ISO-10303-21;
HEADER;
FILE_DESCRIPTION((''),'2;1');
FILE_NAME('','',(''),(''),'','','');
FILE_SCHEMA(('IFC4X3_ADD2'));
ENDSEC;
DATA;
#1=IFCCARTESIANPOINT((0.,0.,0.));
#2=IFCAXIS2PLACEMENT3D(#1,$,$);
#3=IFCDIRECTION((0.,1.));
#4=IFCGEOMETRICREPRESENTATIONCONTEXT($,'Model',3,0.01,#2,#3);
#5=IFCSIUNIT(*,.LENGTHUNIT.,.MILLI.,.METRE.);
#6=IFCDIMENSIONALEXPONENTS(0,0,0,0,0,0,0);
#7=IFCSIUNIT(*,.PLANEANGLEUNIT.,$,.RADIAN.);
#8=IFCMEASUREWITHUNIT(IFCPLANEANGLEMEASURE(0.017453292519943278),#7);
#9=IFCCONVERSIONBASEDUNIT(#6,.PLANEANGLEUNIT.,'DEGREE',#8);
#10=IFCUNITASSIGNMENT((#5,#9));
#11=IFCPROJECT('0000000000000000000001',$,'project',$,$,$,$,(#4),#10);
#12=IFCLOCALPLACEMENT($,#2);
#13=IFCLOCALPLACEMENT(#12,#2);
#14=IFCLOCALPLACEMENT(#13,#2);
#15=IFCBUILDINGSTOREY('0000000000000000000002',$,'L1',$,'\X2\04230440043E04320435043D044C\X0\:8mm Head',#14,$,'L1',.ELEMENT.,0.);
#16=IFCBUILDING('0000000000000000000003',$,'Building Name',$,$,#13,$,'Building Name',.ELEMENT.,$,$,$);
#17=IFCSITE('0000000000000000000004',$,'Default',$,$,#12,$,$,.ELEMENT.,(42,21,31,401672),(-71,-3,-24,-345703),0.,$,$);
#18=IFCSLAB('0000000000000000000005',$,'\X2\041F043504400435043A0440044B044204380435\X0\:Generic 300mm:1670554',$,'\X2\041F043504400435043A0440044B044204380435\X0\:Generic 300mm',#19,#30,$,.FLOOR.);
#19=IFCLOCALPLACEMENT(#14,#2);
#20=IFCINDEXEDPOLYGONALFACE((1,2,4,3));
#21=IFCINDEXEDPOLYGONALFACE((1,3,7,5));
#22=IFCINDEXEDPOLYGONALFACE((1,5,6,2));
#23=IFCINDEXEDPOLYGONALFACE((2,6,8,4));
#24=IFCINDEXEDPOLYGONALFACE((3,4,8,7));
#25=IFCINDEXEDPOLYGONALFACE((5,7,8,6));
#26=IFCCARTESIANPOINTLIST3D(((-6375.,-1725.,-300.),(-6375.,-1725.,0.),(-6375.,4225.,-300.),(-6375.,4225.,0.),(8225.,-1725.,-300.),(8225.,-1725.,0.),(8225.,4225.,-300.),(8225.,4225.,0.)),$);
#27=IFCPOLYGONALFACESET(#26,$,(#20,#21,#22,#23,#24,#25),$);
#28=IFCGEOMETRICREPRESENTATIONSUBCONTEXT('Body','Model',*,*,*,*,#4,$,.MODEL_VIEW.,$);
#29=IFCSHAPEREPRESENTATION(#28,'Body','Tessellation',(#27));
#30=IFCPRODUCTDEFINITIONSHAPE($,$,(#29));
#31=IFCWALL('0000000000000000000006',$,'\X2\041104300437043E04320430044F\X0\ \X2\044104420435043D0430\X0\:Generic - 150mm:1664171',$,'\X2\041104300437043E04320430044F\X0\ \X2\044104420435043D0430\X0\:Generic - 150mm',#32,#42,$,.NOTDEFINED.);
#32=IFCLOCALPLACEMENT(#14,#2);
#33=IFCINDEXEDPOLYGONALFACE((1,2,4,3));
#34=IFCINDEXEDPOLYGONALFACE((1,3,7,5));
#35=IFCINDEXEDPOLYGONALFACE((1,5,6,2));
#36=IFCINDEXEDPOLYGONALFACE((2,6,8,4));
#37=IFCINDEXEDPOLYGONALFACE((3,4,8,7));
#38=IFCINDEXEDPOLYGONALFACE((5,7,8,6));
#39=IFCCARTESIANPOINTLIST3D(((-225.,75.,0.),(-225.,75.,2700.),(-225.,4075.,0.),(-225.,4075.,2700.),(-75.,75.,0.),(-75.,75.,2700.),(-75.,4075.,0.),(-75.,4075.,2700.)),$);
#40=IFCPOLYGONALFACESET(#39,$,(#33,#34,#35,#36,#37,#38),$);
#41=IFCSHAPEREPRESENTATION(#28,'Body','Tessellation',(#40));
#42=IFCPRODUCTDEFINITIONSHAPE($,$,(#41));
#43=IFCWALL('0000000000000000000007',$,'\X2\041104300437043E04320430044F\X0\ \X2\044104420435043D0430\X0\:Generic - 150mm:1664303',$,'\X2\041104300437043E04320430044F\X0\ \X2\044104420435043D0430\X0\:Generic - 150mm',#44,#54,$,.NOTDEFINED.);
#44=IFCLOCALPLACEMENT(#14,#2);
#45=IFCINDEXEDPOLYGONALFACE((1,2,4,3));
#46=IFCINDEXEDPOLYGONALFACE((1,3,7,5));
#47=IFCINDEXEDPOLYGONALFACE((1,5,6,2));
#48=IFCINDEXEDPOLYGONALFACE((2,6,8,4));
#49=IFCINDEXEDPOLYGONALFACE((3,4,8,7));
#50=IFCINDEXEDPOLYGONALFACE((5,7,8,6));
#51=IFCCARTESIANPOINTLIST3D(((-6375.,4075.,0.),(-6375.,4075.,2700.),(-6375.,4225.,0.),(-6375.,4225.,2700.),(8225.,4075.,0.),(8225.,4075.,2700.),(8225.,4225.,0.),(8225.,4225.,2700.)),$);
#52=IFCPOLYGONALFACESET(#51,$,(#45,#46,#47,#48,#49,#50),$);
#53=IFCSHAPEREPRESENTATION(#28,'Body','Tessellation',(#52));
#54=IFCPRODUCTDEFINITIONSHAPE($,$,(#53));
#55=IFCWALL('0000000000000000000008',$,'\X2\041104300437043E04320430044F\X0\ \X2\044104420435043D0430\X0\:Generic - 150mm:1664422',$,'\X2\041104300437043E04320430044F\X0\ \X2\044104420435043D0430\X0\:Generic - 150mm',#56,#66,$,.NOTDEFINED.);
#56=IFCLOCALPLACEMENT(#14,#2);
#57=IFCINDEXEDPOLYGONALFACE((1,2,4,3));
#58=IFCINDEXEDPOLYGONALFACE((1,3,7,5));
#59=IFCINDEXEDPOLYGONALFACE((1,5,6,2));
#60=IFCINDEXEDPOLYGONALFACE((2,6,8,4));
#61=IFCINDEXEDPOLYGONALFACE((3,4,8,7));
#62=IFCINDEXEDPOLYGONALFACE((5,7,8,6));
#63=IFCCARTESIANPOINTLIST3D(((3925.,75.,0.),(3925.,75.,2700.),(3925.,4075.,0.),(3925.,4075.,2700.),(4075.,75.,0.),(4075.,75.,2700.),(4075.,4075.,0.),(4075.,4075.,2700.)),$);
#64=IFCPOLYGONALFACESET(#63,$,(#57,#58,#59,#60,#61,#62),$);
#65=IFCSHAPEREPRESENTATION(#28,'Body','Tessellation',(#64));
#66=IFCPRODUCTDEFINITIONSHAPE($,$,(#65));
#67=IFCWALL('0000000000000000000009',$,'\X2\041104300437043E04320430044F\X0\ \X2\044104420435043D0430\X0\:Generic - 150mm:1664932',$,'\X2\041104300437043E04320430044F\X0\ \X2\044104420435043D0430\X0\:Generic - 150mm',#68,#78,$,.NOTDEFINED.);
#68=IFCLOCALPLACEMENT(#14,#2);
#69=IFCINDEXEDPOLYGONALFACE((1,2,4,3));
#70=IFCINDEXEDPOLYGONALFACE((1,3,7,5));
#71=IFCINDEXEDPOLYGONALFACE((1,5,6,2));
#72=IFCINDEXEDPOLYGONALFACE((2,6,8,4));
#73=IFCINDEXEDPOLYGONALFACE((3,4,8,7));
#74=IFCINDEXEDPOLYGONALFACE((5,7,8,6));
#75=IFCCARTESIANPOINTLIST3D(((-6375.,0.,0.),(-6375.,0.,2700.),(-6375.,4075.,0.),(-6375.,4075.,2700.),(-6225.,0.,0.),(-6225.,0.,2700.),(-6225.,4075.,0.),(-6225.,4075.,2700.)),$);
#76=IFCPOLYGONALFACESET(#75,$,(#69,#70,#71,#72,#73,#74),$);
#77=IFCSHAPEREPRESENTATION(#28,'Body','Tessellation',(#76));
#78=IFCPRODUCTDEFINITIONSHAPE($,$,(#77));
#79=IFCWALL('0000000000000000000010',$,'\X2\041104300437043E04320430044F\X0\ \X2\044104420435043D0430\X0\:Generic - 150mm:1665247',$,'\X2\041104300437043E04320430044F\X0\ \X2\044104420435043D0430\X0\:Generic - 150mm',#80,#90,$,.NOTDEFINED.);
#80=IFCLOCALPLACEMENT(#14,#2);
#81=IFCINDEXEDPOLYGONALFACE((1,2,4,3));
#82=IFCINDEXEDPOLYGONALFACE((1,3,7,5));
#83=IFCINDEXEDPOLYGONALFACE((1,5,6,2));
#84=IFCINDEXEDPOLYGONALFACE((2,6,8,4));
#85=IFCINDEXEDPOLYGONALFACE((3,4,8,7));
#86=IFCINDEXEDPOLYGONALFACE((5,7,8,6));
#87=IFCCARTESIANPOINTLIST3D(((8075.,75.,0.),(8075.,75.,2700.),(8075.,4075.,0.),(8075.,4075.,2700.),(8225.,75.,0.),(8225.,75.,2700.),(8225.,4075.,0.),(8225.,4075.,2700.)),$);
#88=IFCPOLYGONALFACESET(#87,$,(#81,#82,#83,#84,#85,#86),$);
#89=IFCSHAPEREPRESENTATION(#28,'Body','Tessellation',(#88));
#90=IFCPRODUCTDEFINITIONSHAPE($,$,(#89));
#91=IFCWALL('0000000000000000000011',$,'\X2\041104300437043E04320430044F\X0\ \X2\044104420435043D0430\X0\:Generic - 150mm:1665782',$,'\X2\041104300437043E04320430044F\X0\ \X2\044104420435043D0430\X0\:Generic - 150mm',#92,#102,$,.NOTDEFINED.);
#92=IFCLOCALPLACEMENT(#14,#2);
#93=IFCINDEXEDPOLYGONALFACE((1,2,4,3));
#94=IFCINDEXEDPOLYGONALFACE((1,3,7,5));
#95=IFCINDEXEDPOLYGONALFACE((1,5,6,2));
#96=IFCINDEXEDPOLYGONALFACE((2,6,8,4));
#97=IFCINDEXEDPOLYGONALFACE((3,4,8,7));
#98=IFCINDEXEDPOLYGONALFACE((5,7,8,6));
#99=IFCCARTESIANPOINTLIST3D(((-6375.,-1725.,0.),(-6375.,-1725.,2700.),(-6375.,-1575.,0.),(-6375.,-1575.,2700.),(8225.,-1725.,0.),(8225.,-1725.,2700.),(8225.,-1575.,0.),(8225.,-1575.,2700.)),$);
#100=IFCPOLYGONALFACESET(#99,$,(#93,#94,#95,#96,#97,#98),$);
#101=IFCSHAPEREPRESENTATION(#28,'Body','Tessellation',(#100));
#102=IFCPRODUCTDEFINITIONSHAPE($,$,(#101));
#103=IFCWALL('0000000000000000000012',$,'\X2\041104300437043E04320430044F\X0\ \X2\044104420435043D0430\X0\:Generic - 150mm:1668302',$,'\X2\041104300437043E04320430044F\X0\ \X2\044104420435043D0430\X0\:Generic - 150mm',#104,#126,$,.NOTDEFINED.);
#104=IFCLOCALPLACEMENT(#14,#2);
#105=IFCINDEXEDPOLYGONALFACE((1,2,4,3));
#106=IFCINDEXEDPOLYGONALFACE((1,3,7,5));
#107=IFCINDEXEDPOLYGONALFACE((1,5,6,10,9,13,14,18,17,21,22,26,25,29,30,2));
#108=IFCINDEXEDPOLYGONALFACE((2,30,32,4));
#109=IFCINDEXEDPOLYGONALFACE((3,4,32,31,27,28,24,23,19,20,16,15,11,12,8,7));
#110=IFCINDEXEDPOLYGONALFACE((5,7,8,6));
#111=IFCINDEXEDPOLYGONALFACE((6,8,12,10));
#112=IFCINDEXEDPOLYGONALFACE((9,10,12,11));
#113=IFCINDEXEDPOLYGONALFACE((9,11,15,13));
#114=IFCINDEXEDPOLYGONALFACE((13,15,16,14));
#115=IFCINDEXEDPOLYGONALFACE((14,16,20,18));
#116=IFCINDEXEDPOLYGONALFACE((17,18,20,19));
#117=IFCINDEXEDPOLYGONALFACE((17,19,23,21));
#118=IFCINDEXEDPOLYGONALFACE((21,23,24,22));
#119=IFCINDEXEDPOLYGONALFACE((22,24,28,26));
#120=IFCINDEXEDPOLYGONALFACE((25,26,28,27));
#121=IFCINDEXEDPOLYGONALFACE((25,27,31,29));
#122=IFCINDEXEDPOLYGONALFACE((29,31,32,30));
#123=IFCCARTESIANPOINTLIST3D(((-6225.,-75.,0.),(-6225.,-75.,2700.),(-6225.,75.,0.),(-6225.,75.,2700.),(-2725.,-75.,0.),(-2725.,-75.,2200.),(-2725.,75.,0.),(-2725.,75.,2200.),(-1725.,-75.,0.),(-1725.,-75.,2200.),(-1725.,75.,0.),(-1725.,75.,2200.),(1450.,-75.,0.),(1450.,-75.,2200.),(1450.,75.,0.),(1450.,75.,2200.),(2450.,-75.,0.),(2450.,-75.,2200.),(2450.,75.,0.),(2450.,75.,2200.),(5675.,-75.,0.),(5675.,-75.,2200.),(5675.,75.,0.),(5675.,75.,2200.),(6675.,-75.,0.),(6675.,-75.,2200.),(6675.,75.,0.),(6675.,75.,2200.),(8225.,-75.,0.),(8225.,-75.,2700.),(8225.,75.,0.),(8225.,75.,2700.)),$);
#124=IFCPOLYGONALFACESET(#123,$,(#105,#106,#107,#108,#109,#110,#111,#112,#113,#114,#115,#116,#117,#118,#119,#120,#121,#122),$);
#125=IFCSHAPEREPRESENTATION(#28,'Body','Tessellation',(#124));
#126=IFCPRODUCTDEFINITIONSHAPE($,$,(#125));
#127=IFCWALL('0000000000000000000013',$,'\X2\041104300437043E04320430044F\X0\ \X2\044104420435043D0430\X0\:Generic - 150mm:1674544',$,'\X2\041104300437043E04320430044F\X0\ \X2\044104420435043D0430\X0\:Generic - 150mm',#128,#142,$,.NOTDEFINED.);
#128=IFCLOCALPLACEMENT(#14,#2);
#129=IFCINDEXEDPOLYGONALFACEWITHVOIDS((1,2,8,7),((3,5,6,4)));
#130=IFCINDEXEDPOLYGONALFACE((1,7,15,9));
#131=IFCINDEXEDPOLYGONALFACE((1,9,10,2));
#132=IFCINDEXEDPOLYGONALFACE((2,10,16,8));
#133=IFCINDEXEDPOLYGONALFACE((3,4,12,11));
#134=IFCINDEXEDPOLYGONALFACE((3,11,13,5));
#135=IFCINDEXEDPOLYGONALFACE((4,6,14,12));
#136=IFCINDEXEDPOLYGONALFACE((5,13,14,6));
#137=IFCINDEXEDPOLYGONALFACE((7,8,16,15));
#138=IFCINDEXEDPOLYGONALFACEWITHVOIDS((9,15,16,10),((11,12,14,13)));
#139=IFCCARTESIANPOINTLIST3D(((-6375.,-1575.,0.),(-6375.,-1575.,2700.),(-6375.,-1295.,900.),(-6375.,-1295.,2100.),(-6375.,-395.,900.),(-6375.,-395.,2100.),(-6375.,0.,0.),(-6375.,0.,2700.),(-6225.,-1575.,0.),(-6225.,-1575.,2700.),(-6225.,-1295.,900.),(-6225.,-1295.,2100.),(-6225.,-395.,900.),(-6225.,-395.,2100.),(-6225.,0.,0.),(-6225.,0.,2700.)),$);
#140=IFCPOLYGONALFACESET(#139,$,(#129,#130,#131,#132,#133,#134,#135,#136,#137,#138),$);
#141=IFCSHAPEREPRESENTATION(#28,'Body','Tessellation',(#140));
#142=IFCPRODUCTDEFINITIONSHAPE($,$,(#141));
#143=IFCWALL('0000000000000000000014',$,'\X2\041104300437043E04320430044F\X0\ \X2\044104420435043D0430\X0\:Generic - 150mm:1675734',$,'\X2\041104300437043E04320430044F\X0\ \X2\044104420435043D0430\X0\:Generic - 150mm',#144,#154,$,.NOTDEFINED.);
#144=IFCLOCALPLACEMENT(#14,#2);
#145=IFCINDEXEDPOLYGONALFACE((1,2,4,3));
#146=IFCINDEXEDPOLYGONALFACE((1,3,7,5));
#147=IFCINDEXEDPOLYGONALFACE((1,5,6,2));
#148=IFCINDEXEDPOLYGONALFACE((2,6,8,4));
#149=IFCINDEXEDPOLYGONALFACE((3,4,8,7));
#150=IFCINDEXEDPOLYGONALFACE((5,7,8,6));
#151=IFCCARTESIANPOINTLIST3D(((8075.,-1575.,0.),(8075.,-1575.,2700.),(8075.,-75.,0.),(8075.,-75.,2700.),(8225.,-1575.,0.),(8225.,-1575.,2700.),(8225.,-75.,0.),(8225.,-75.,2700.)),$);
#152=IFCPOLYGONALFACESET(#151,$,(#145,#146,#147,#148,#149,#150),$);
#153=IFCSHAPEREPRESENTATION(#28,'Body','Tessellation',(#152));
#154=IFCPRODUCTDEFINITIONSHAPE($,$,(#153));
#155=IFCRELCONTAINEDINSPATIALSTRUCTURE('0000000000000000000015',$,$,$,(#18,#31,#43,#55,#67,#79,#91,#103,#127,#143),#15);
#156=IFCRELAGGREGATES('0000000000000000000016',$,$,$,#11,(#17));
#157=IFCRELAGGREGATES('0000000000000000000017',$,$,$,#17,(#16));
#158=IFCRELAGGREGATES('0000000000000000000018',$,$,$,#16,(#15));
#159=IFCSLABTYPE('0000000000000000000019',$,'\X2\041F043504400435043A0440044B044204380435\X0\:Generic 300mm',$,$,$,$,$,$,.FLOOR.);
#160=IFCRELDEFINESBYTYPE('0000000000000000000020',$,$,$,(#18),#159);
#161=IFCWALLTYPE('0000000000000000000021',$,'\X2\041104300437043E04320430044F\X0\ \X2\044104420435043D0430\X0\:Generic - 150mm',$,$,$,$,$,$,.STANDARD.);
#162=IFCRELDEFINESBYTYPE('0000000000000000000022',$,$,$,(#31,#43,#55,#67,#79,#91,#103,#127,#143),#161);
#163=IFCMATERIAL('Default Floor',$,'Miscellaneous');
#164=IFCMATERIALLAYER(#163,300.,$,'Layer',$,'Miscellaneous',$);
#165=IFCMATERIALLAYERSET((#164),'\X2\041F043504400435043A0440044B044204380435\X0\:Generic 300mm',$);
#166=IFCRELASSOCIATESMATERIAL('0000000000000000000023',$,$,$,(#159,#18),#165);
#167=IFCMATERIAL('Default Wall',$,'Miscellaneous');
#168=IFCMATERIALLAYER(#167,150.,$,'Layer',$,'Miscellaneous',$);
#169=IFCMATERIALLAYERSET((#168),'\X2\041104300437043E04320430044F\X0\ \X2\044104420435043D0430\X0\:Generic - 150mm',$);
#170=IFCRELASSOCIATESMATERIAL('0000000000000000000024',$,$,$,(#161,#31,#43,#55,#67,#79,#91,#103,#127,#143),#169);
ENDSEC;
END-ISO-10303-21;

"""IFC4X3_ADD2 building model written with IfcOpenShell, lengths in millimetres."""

from ifc_helpers import new_model, entity, si_unit, converted_unit, direction, frame, frame_2d, origin, origin_2d_with_axis, place, context, subcontext, project, spatial, rectangle, extrude, material, layer, layer_set, layer_usage, type_object, element, save


model = new_model("IFC4X3_ADD2")

# Units and contexts
model_context = context("Model", 3, precision=0.01, world=origin(), true_north=direction((0.0, 1.0)))
body_context = subcontext(model_context, "Body", "Model", "MODEL_VIEW")
ifc_project = project(units=[si_unit("LENGTHUNIT", "METRE", prefix="MILLI"), converted_unit("PLANEANGLEUNIT", "DEGREE", entity("IfcPlaneAngleMeasure", 0.017453292519943278), si_unit("PLANEANGLEUNIT", "RADIAN"), dimensions=[0, 0, 0, 0, 0, 0, 0])], contexts=[model_context])

# Site, building, storey
site_placement = place(None, origin())
site = spatial("IfcSite", under=ifc_project, at=site_placement, Name="Default", CompositionType="ELEMENT", RefLatitude=(42, 21, 31, 401672), RefLongitude=(-71, -3, -24, -345703), RefElevation=0.0)
building_placement = place(site_placement, origin())
building = spatial("IfcBuilding", under=site, at=building_placement, Name="Building Name", LongName="Building Name", CompositionType="ELEMENT")
storey_placement = place(building_placement, origin())
storey = spatial("IfcBuildingStorey", under=building, at=storey_placement, Name="L1", ObjectType="Уровень:8mm Head", LongName="L1", CompositionType="ELEMENT", Elevation=0.0)

# Slab
ifc_material_1 = material(Name="Default Floor", Category="Miscellaneous")
ifc_layer_1 = layer(ifc_material_1, 300.0, Name="Layer", Category="Miscellaneous")
ifc_layer_set_1 = layer_set([ifc_layer_1], Name="Перекрытие:Generic 300mm")
ifc_layer_usage = layer_usage(ifc_layer_set_1, "AXIS3", "POSITIVE", 0.0)
slab_type = type_object("IfcSlabType", Name="Перекрытие:Generic 300mm", PredefinedType="FLOOR", material=ifc_layer_set_1)
slab_placement = place(storey_placement, origin())
element("IfcSlab", 1, at=slab_placement, inside=storey, type_object=slab_type, material=ifc_layer_usage, Name="Перекрытие:Generic 300mm:1670554", ObjectType="Перекрытие:Generic 300mm", PredefinedType="FLOOR", context=body_context, shape_type="SweptSolid", body=[
    extrude(rectangle(XDim=5950.0, YDim=14600.0, at=origin_2d_with_axis()), frame((925.0, 1250.0, 0.0), z_axis=(0.0, 0.0, -1.0), x_axis=(0.0, 1.0, 0.0)), (0.0, 0.0, 1.0), 300.0),
])

# Walls
ifc_material_2 = material(Name="Default Wall", Category="Miscellaneous")
ifc_layer_2 = layer(ifc_material_2, 150.0, Name="Layer", Category="Miscellaneous")
ifc_layer_set_2 = layer_set([ifc_layer_2], Name="Базовая стена:Generic - 150mm")
wall_type = type_object("IfcWallType", Name="Базовая стена:Generic - 150mm", PredefinedType="STANDARD", material=ifc_layer_set_2)
wall_1_placement = place(storey_placement, frame((-150.0, 75.0, 0.0), z_axis=(0.0, 0.0, 1.0), x_axis=(0.0, 1.0, 0.0)))
element("IfcWall", 2, at=wall_1_placement, inside=storey, type_object=wall_type, material=ifc_layer_set_2, Name="Базовая стена:Generic - 150mm:1664171", ObjectType="Базовая стена:Generic - 150mm", PredefinedType="NOTDEFINED", context=body_context, shape_type="SweptSolid", body=[
    extrude(rectangle(XDim=4000.0, YDim=150.0, at=frame_2d((2000.0, 0.0), x_axis=(-1.0, 0.0))), origin(), (0.0, 0.0, 1.0), 2700.0),
])
wall_2_placement = place(storey_placement, frame((-6375.0, 4150.0, 0.0)))
element("IfcWall", 3, at=wall_2_placement, inside=storey, type_object=wall_type, material=ifc_layer_set_2, Name="Базовая стена:Generic - 150mm:1664303", ObjectType="Базовая стена:Generic - 150mm", PredefinedType="NOTDEFINED", context=body_context, shape_type="SweptSolid", body=[
    extrude(rectangle(XDim=14600.0, YDim=150.0, at=frame_2d((7300.0, 0.0), x_axis=(-1.0, 0.0))), origin(), (0.0, 0.0, 1.0), 2700.0),
])
wall_3_placement = place(storey_placement, frame((4000.0, 4075.0, 0.0), z_axis=(0.0, 0.0, 1.0), x_axis=(0.0, -1.0, 0.0)))
element("IfcWall", 4, at=wall_3_placement, inside=storey, type_object=wall_type, material=ifc_layer_set_2, Name="Базовая стена:Generic - 150mm:1664422", ObjectType="Базовая стена:Generic - 150mm", PredefinedType="NOTDEFINED", context=body_context, shape_type="SweptSolid", body=[
    extrude(rectangle(XDim=4000.0, YDim=150.0, at=frame_2d((2000.0, 0.0), x_axis=(-1.0, 0.0))), origin(), (0.0, 0.0, 1.0), 2700.0),
])
wall_4_placement = place(storey_placement, frame((-6300.0, 4075.0, 0.0), z_axis=(0.0, 0.0, 1.0), x_axis=(0.0, -1.0, 0.0)))
element("IfcWall", 5, at=wall_4_placement, inside=storey, type_object=wall_type, material=ifc_layer_set_2, Name="Базовая стена:Generic - 150mm:1664932", ObjectType="Базовая стена:Generic - 150mm", PredefinedType="NOTDEFINED", context=body_context, shape_type="SweptSolid", body=[
    extrude(rectangle(XDim=4075.0, YDim=150.0, at=frame_2d((2037.5, 0.0), x_axis=(-1.0, 0.0))), origin(), (0.0, 0.0, 1.0), 2700.0),
])
wall_5_placement = place(storey_placement, frame((8150.0, 4075.0, 0.0), z_axis=(0.0, 0.0, 1.0), x_axis=(0.0, -1.0, 0.0)))
element("IfcWall", 6, at=wall_5_placement, inside=storey, type_object=wall_type, material=ifc_layer_set_2, Name="Базовая стена:Generic - 150mm:1665247", ObjectType="Базовая стена:Generic - 150mm", PredefinedType="NOTDEFINED", context=body_context, shape_type="SweptSolid", body=[
    extrude(rectangle(XDim=4000.0, YDim=150.0, at=frame_2d((2000.0, 0.0), x_axis=(-1.0, 0.0))), origin(), (0.0, 0.0, 1.0), 2700.0),
])
wall_6_placement = place(storey_placement, frame((8225.0, -1650.0, 0.0), z_axis=(0.0, 0.0, 1.0), x_axis=(-1.0, 0.0, 0.0)))
element("IfcWall", 7, at=wall_6_placement, inside=storey, type_object=wall_type, material=ifc_layer_set_2, Name="Базовая стена:Generic - 150mm:1665782", ObjectType="Базовая стена:Generic - 150mm", PredefinedType="NOTDEFINED", context=body_context, shape_type="SweptSolid", body=[
    extrude(rectangle(XDim=14600.0, YDim=150.0, at=frame_2d((7300.0, 0.0), x_axis=(-1.0, 0.0))), origin(), (0.0, 0.0, 1.0), 2700.0),
])

# Wall, openings
wall_7_placement = place(storey_placement, frame((8225.0, 0.0, 0.0), z_axis=(0.0, 0.0, 1.0), x_axis=(-1.0, 0.0, 0.0)))
wall_7 = element("IfcWall", 8, at=wall_7_placement, inside=storey, type_object=wall_type, material=ifc_layer_set_2, Name="Базовая стена:Generic - 150mm:1668302", ObjectType="Базовая стена:Generic - 150mm", PredefinedType="NOTDEFINED", context=body_context, shape_type="SweptSolid", body=[
    extrude(rectangle(XDim=14450.0, YDim=150.0, at=frame_2d((7225.0, 0.0), x_axis=(-1.0, 0.0))), origin(), (0.0, 0.0, 1.0), 2700.0),
])
opening_1_placement = place(wall_7_placement, frame((6775.0, 75.0, 0.0)))
element("IfcOpeningElement", 9, at=opening_1_placement, cuts=wall_7, PredefinedType="OPENING", context=body_context, shape_type="SweptSolid", body=[
    extrude(rectangle(XDim=2200.0, YDim=1000.0, at=frame_2d((1100.0, 500.0), x_axis=(1.0, 0.0))), frame((0.0, 0.0, 0.0), z_axis=(0.0, -1.0, 0.0), x_axis=(0.0, 0.0, 1.0)), (0.0, 0.0, 1.0), 150.0),
])
opening_2_placement = place(wall_7_placement, frame((8225.0, 0.0, 0.0), z_axis=(0.0, 0.0, 1.0), x_axis=(-1.0, 0.0, 0.0)))
element("IfcOpeningElement", 10, at=opening_2_placement, cuts=wall_7, PredefinedType="OPENING", context=body_context, shape_type="SweptSolid", body=[
    extrude(rectangle(XDim=2200.0, YDim=1000.0, at=frame_2d((0.0, 0.0), x_axis=(1.0, 0.0))), frame((1950.0, 1449.0, 1100.0), z_axis=(0.0, -1.0, 0.0), x_axis=(0.0, 0.0, 1.0)), (0.0, 0.0, 1.0), 3048.0),
])
opening_3_placement = place(wall_7_placement, frame((10950.0, 75.0, 0.0)))
element("IfcOpeningElement", 11, at=opening_3_placement, cuts=wall_7, PredefinedType="OPENING", context=body_context, shape_type="SweptSolid", body=[
    extrude(rectangle(XDim=2200.0, YDim=1000.0, at=frame_2d((1100.0, 500.0), x_axis=(1.0, 0.0))), frame((0.0, 0.0, 0.0), z_axis=(0.0, -1.0, 0.0), x_axis=(0.0, 0.0, 1.0)), (0.0, 0.0, 1.0), 150.0),
])
opening_4_placement = place(wall_7_placement, frame((1550.0, -75.0, 0.0)))
element("IfcOpeningElement", 12, at=opening_4_placement, cuts=wall_7, PredefinedType="OPENING", context=body_context, shape_type="SweptSolid", body=[
    extrude(rectangle(XDim=2200.0, YDim=1000.0, at=frame_2d((1100.0, 500.0), x_axis=(1.0, 0.0))), frame((0.0, 0.0, 0.0), z_axis=(0.0, 1.0, 0.0), x_axis=(0.0, 0.0, 1.0)), (0.0, 0.0, 1.0), 150.0),
])

# Wall, opening
wall_8_placement = place(storey_placement, frame((-6300.0, 0.0, 0.0), z_axis=(0.0, 0.0, 1.0), x_axis=(0.0, -1.0, 0.0)))
wall_8 = element("IfcWall", 13, at=wall_8_placement, inside=storey, type_object=wall_type, material=ifc_layer_set_2, Name="Базовая стена:Generic - 150mm:1674544", ObjectType="Базовая стена:Generic - 150mm", PredefinedType="NOTDEFINED", context=body_context, shape_type="SweptSolid", body=[
    extrude(rectangle(XDim=1575.0, YDim=150.0, at=frame_2d((787.5, 0.0), x_axis=(-1.0, 0.0))), origin(), (0.0, 0.0, 1.0), 2700.0),
])
opening_5_placement = place(wall_8_placement, frame((1295.0, 75.0, 900.0)))
element("IfcOpeningElement", 14, at=opening_5_placement, cuts=wall_8, PredefinedType="OPENING", context=body_context, shape_type="SweptSolid", body=[
    extrude(rectangle(XDim=1200.0, YDim=900.0, at=frame_2d((600.0, 450.0), x_axis=(-1.0, 0.0))), frame((0.0, 0.0, 0.0), z_axis=(0.0, -1.0, 0.0), x_axis=(0.0, 0.0, 1.0)), (0.0, 0.0, 1.0), 150.0),
])

# Wall
wall_9_placement = place(storey_placement, frame((8150.0, -75.0, 0.0), z_axis=(0.0, 0.0, 1.0), x_axis=(0.0, -1.0, 0.0)))
element("IfcWall", 15, at=wall_9_placement, inside=storey, type_object=wall_type, material=ifc_layer_set_2, Name="Базовая стена:Generic - 150mm:1675734", ObjectType="Базовая стена:Generic - 150mm", PredefinedType="NOTDEFINED", context=body_context, shape_type="SweptSolid", body=[
    extrude(rectangle(XDim=1500.0, YDim=150.0, at=frame_2d((750.0, 0.0), x_axis=(-1.0, 0.0))), origin(), (0.0, 0.0, 1.0), 2700.0),
])

save(model, "model.ifc")
